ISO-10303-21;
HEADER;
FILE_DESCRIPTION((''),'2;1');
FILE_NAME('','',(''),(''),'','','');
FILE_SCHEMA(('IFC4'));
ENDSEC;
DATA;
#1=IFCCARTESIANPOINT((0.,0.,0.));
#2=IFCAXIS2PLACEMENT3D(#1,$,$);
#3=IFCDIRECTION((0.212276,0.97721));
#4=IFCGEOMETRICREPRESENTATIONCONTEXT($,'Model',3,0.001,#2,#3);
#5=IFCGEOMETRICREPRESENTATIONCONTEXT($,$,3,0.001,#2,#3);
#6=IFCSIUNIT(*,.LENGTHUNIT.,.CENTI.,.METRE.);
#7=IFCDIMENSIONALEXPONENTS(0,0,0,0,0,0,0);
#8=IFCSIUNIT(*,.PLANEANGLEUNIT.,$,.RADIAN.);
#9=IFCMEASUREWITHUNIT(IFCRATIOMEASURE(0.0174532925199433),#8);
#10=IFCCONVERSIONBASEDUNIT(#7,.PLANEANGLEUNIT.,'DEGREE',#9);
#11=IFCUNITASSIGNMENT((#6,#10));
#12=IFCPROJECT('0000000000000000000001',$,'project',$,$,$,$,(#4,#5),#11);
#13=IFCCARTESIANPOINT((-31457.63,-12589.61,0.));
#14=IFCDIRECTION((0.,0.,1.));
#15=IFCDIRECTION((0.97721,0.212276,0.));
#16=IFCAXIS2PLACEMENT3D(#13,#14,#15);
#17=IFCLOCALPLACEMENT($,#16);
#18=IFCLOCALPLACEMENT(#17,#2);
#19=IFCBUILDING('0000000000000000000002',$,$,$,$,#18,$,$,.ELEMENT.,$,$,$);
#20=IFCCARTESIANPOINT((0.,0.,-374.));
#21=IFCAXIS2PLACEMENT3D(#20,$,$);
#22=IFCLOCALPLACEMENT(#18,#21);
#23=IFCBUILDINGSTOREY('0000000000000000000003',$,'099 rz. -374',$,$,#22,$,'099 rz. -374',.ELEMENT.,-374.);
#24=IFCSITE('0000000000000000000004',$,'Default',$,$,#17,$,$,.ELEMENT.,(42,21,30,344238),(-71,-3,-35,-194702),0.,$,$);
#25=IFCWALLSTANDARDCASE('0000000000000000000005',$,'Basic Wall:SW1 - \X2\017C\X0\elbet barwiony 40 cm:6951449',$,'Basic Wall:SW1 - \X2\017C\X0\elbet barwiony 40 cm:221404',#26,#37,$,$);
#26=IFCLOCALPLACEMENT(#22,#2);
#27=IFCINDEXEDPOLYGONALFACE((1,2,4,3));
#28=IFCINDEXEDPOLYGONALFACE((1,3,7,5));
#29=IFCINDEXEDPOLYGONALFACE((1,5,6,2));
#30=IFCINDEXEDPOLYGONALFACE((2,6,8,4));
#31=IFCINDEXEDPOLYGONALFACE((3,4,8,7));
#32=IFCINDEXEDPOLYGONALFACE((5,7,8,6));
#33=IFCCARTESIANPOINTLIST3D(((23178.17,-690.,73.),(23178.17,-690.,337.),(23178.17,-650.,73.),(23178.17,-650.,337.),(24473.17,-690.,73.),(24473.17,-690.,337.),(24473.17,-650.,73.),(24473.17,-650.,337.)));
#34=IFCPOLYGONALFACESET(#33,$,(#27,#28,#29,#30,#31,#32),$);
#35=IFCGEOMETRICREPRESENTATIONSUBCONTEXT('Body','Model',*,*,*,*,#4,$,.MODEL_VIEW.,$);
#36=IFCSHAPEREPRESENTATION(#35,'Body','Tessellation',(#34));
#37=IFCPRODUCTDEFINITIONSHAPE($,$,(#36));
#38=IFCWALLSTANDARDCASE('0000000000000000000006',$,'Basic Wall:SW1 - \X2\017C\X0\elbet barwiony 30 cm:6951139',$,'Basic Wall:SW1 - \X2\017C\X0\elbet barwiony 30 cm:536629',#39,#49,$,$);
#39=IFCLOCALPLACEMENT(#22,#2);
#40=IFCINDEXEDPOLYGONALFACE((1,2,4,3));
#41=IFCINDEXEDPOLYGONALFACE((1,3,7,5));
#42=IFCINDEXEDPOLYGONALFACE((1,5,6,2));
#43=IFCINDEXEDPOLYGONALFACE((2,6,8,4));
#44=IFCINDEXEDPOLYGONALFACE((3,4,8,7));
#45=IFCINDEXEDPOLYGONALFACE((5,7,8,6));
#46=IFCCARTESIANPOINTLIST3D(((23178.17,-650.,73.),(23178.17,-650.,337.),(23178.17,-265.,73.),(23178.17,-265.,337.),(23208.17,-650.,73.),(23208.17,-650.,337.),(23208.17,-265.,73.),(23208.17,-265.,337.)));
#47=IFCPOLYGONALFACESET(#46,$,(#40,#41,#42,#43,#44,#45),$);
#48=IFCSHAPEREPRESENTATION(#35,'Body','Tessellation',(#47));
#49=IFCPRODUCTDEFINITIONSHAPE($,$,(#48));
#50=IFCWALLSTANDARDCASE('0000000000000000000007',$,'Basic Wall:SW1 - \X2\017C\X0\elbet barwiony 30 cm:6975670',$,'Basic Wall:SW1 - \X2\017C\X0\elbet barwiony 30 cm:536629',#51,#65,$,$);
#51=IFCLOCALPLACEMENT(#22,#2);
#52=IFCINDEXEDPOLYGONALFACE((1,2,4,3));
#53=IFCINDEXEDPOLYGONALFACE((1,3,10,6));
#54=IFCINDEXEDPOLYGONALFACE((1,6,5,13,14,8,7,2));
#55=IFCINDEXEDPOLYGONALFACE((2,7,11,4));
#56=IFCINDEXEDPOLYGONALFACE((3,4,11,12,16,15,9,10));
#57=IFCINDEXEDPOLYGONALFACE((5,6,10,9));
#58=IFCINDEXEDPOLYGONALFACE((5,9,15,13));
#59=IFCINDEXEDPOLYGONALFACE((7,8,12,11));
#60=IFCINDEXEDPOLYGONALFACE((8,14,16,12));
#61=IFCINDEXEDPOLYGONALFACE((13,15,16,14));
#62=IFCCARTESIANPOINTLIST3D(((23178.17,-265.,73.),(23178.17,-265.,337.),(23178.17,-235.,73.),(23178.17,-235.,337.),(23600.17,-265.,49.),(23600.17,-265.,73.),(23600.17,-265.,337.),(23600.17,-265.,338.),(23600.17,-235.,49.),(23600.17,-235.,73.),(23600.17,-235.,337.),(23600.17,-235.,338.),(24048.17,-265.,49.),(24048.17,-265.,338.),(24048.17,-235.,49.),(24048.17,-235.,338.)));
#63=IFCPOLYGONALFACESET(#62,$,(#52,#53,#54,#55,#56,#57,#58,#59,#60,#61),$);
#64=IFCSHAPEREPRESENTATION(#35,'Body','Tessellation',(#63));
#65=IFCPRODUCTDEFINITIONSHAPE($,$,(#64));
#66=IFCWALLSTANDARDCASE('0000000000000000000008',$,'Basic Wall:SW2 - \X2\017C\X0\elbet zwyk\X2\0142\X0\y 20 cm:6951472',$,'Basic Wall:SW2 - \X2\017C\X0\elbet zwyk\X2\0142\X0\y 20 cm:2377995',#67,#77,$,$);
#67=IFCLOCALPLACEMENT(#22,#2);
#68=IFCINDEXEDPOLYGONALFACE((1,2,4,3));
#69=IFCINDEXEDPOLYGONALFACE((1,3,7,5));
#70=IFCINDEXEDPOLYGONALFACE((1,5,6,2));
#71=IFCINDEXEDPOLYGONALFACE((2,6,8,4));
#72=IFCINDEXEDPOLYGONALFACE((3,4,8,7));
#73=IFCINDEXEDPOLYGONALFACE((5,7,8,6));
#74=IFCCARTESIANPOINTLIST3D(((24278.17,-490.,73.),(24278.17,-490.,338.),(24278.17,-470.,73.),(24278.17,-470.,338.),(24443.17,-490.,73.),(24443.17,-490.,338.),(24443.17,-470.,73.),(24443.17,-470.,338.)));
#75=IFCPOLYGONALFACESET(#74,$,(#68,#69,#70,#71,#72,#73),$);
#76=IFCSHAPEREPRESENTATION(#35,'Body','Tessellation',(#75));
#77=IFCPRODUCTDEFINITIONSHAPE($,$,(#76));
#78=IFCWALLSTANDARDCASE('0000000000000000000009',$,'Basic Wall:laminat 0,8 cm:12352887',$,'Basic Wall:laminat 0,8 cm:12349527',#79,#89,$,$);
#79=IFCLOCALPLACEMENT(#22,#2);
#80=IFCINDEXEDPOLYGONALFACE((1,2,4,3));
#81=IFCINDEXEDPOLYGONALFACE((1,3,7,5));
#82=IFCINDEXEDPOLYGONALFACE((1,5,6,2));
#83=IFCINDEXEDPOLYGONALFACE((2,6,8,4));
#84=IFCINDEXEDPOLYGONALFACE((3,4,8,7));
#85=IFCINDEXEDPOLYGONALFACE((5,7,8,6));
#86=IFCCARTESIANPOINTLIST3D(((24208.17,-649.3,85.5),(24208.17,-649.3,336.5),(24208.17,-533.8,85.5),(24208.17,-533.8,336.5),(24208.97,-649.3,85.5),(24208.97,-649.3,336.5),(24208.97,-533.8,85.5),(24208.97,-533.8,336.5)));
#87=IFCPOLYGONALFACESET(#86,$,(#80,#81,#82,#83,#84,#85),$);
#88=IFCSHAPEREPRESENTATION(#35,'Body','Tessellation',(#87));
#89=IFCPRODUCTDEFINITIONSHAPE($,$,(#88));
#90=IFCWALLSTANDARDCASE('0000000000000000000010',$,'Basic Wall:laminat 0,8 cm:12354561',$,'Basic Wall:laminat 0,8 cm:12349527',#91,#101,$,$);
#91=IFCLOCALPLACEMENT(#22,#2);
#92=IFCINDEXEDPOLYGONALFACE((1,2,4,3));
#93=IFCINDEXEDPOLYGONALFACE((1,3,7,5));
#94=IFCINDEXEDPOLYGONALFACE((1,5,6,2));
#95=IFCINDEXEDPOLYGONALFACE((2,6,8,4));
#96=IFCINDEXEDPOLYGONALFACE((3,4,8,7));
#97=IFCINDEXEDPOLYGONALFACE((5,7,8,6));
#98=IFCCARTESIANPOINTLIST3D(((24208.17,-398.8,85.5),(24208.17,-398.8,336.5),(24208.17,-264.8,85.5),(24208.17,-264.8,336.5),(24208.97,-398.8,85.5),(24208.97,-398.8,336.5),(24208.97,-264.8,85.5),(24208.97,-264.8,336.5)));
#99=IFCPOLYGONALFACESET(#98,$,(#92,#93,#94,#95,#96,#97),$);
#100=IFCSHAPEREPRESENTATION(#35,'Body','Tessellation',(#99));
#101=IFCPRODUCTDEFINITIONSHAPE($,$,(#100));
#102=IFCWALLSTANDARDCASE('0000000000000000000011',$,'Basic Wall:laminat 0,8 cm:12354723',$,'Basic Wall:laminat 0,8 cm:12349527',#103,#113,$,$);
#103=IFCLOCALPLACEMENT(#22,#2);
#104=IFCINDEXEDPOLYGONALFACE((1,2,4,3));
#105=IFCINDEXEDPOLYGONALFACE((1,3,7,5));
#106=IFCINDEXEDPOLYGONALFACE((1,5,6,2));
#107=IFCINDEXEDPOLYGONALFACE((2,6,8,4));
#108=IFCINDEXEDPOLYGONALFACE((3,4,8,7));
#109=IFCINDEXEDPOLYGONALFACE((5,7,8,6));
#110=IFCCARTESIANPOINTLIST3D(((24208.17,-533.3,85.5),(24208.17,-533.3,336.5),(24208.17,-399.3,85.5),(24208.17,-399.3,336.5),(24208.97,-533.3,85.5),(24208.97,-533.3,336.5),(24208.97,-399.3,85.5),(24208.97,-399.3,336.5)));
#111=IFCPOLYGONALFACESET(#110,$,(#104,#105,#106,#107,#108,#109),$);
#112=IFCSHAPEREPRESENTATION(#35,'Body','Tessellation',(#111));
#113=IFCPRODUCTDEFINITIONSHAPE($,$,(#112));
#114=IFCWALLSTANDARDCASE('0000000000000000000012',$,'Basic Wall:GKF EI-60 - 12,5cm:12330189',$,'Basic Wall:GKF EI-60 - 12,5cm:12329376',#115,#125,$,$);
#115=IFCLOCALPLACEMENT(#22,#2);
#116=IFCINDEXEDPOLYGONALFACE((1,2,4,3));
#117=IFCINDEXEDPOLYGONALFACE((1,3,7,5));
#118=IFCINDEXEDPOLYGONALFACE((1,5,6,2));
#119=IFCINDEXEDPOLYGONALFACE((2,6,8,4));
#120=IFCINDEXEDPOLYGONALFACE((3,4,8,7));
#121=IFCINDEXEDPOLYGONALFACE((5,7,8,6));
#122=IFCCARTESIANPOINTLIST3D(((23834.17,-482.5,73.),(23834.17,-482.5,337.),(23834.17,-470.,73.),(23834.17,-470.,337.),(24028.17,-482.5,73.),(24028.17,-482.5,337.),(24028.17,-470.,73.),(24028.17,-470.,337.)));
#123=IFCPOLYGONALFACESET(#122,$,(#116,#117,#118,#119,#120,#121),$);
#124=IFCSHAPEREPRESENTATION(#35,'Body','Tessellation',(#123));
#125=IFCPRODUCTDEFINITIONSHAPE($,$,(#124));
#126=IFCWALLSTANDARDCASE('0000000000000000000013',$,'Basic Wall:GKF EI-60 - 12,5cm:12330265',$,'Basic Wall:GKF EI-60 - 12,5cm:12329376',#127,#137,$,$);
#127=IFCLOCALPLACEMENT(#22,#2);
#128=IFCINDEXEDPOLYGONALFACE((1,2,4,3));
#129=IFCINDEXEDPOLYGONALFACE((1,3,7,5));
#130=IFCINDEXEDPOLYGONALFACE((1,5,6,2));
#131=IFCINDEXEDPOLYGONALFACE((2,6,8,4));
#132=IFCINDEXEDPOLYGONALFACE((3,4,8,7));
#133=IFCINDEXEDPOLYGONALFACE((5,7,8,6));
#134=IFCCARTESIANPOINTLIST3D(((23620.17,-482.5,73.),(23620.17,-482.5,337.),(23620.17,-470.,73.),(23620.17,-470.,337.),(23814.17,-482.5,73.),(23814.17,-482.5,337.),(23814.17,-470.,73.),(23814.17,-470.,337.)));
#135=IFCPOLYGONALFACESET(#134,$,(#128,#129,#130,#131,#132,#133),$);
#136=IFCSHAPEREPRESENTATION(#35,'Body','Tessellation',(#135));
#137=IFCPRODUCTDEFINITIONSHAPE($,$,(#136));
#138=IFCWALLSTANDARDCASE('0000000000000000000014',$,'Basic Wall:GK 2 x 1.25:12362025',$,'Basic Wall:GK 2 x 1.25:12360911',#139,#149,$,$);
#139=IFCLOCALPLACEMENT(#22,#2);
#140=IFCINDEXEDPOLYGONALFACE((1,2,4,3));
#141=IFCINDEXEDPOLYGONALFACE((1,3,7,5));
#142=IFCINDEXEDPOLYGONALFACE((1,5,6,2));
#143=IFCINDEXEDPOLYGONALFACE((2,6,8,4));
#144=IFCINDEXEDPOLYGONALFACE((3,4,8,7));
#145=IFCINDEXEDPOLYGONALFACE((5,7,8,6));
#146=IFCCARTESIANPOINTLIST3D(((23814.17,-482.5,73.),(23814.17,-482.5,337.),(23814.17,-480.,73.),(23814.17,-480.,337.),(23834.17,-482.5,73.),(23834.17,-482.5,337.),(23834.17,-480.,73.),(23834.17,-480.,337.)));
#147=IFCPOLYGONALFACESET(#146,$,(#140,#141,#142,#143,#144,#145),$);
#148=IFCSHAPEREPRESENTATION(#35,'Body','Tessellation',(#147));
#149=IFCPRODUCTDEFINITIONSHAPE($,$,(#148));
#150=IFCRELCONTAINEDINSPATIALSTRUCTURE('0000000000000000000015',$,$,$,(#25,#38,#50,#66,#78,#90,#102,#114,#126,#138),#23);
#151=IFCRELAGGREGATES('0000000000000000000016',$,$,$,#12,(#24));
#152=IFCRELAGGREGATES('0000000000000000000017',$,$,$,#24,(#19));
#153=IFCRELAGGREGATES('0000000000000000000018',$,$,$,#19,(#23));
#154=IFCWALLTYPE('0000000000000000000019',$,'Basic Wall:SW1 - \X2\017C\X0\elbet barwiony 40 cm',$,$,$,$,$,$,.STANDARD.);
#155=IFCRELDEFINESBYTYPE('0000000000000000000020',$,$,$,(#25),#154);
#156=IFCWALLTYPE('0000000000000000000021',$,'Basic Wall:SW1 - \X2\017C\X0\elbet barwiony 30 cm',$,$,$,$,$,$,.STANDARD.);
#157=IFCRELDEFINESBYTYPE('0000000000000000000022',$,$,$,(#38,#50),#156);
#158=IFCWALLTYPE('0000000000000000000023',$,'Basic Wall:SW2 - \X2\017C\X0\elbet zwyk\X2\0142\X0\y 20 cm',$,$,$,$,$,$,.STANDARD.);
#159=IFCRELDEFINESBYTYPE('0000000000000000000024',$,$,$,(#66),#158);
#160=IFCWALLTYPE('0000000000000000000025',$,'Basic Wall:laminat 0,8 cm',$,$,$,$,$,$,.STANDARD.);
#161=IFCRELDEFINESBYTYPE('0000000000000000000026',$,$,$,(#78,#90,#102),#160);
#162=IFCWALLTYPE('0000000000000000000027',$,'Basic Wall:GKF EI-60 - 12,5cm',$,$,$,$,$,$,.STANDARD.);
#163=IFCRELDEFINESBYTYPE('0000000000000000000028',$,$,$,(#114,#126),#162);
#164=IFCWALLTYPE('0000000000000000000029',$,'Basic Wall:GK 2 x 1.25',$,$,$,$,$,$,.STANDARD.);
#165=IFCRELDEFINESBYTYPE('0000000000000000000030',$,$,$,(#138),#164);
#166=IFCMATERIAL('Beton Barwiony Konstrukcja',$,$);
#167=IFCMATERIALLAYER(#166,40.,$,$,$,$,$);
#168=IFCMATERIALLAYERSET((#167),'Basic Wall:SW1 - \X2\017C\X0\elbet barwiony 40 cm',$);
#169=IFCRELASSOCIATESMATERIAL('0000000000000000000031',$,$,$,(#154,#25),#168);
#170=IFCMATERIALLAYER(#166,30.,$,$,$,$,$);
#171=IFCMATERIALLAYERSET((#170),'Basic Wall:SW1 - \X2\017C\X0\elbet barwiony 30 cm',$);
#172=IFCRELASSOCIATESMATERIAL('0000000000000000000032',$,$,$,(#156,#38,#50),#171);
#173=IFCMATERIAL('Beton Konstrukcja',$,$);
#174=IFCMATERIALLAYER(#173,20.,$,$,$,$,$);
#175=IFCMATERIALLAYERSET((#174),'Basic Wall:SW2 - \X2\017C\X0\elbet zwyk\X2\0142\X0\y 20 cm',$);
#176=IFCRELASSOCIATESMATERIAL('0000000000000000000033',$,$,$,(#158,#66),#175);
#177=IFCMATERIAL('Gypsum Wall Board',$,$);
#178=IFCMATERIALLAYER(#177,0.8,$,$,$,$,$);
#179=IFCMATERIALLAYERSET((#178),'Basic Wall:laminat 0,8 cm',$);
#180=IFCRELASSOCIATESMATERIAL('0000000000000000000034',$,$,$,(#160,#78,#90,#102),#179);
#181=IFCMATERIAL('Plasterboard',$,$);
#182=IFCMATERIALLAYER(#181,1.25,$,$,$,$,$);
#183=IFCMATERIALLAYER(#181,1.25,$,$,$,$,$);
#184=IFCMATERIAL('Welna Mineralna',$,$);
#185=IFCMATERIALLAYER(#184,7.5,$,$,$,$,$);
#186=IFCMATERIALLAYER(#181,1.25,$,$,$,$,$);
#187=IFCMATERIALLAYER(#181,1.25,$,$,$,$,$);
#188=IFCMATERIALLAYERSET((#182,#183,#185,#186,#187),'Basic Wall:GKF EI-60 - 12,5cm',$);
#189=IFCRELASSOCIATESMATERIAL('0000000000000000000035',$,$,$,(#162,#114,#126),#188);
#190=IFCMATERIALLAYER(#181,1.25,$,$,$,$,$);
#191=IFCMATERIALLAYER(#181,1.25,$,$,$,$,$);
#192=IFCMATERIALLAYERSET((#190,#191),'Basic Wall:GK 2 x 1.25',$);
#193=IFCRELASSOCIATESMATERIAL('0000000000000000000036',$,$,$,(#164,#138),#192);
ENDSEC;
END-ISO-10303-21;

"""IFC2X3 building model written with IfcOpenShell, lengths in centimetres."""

from ifc_helpers import new_model, entity, si_unit, converted_unit, direction, frame, frame_2d, origin, place, context, subcontext, project, spatial, polyline, rectangle, extrude, clip, bounded_halfspace, material, layer, layer_set, layer_usage, type_object, element, save


model = new_model("IFC2X3")

# Units and contexts
model_context = context("Model", 3, precision=0.001, world=origin(), true_north=direction((0.212276, 0.97721)))
context_of_model = context(None, 3, precision=0.001, world=origin(), true_north=direction((0.212276, 0.97721)))
body_context = subcontext(model_context, "Body", "Model", "MODEL_VIEW")
ifc_project = project(units=[si_unit("LENGTHUNIT", "METRE", prefix="CENTI"), converted_unit("PLANEANGLEUNIT", "DEGREE", entity("IfcRatioMeasure", 0.0174532925199433), si_unit("PLANEANGLEUNIT", "RADIAN"), dimensions=[0, 0, 0, 0, 0, 0, 0])], contexts=[model_context, context_of_model])

# Site, building, storey
site_placement = place(None, frame((-31457.63, -12589.61, 0.0), z_axis=(0.0, 0.0, 1.0), x_axis=(0.97721, 0.212276, 0.0)))
site = spatial("IfcSite", under=ifc_project, at=site_placement, Name="Default", CompositionType="ELEMENT", RefLatitude=(42, 21, 30, 344238), RefLongitude=(-71, -3, -35, -194702), RefElevation=0.0)
building_placement = place(site_placement, origin())
building = spatial("IfcBuilding", under=site, at=building_placement, CompositionType="ELEMENT")
storey_placement = place(building_placement, frame((0.0, 0.0, -374.0)))
storey = spatial("IfcBuildingStorey", under=building, at=storey_placement, Name="099 rz. -374", LongName="099 rz. -374", CompositionType="ELEMENT", Elevation=-374.0)

# Shared definitions
ifc_material_1 = material(Name="Beton Konstrukcja")

# Walls
ifc_material_2 = material(Name="Beton Barwiony Konstrukcja")
ifc_layer_1 = layer(ifc_material_2, 40.0)
ifc_layer_set_1 = layer_set([ifc_layer_1], Name="Basic Wall:SW1 - żelbet barwiony 40 cm")
ifc_layer_usage_1 = layer_usage(ifc_layer_set_1, "AXIS2", "POSITIVE", -20.0)
wall_type_1 = type_object("IfcWallType", Name="Basic Wall:SW1 - żelbet barwiony 40 cm", PredefinedType="STANDARD", material=ifc_layer_set_1)
wall_1_placement = place(storey_placement, frame((23178.17, -670.0, 73.0)))
element("IfcWallStandardCase", 1, at=wall_1_placement, inside=storey, type_object=wall_type_1, material=ifc_layer_usage_1, Name="Basic Wall:SW1 - żelbet barwiony 40 cm:6951449", ObjectType="Basic Wall:SW1 - żelbet barwiony 40 cm:221404", context=body_context, shape_type="Clipping", body=[
    clip(clip(extrude(rectangle(XDim=1295.0, YDim=40.0, at=frame_2d((647.5, 0.0), x_axis=(-1.0, 0.0))), origin(), (0.0, 0.0, 1.0), 265.0), bounded_halfspace(frame((1295.0, -20.0, 0.0), z_axis=(0.0, 0.0, 1.0), x_axis=(0.0, -1.0, 0.0)), True, frame((1295.0, -20.0, 0.0)), polyline([(0.0, 0.0), (0.0, 40.0), (-30.0, 40.0), (-1265.0, 40.0), (-1295.0, 40.0), (-1295.0, 0.0), (0.0, 0.0)]))), bounded_halfspace(frame((0.0, -20.0, 264.0), z_axis=(0.0, 0.0, -1.0), x_axis=(1.0, 0.0, 0.0)), True, frame((0.0, -20.0, 264.0), z_axis=(0.0, 0.0, -1.0), x_axis=(1.0, 0.0, 0.0)), polyline([(0.0, 0.0), (0.0, -40.0), (30.0, -40.0), (1265.0, -40.0), (1295.0, -40.0), (1295.0, 0.0), (0.0, 0.0)]))),
])
ifc_layer_2 = layer(ifc_material_2, 30.0)
ifc_layer_set_2 = layer_set([ifc_layer_2], Name="Basic Wall:SW1 - żelbet barwiony 30 cm")
ifc_layer_usage_2 = layer_usage(ifc_layer_set_2, "AXIS2", "POSITIVE", -15.0)
wall_type_2 = type_object("IfcWallType", Name="Basic Wall:SW1 - żelbet barwiony 30 cm", PredefinedType="STANDARD", material=ifc_layer_set_2)
wall_2_placement = place(storey_placement, frame((23193.17, -265.0, 73.0), z_axis=(0.0, 0.0, 1.0), x_axis=(0.0, -1.0, 0.0)))
element("IfcWallStandardCase", 2, at=wall_2_placement, inside=storey, type_object=wall_type_2, material=ifc_layer_usage_2, Name="Basic Wall:SW1 - żelbet barwiony 30 cm:6951139", ObjectType="Basic Wall:SW1 - żelbet barwiony 30 cm:536629", context=body_context, shape_type="Clipping", body=[
    clip(clip(extrude(rectangle(XDim=385.0, YDim=30.0, at=frame_2d((192.5, 0.0), x_axis=(-1.0, 0.0))), origin(), (0.0, 0.0, 1.0), 265.0), bounded_halfspace(frame((385.0, -15.0, 0.0)), True, frame((385.0, -15.0, 0.0)), polyline([(0.0, 0.0), (0.0, 30.0), (-385.0, 30.0), (-385.0, 0.0), (0.0, 0.0)]))), bounded_halfspace(frame((0.0, -15.0, 264.0), z_axis=(0.0, 0.0, -1.0), x_axis=(0.0, 1.0, 0.0)), True, frame((0.0, -15.0, 264.0), z_axis=(0.0, 0.0, -1.0), x_axis=(0.0, 1.0, 0.0)), polyline([(0.0, 0.0), (30.0, 0.0), (30.0, 385.0), (0.0, 385.0), (0.0, 0.0)]))),
])
ifc_layer_usage_3 = layer_usage(ifc_layer_set_2, "AXIS2", "POSITIVE", -15.0)
wall_3_placement = place(storey_placement, frame((24048.17, -250.0, 49.0), z_axis=(0.0, 0.0, 1.0), x_axis=(-1.0, 0.0, 0.0)))
element("IfcWallStandardCase", 3, at=wall_3_placement, inside=storey, type_object=wall_type_2, material=ifc_layer_usage_3, Name="Basic Wall:SW1 - żelbet barwiony 30 cm:6975670", ObjectType="Basic Wall:SW1 - żelbet barwiony 30 cm:536629", context=body_context, shape_type="Clipping", body=[
    clip(clip(clip(extrude(rectangle(XDim=870.0, YDim=30.0, at=frame_2d((435.0, 0.0), x_axis=(-1.0, 0.0))), origin(), (0.0, 0.0, 1.0), 289.0), bounded_halfspace(frame((870.0, 15.0, 24.0), z_axis=(0.0, 0.0, 1.0), x_axis=(0.0, 1.0, 0.0)), True, frame((870.0, 15.0, 24.0)), polyline([(0.0, 0.0), (-30.0, 0.0), (-422.0, 0.0), (-422.0, -30.0), (0.0, -30.0), (0.0, 0.0)]))), bounded_halfspace(frame((448.0, 15.0, 288.0), z_axis=(0.0, 0.0, -1.0), x_axis=(-1.0, 0.0, 0.0)), True, frame((448.0, 15.0, 288.0), z_axis=(0.0, 0.0, -1.0), x_axis=(-1.0, 0.0, 0.0)), polyline([(0.0, 0.0), (-392.0, 0.0), (-422.0, 0.0), (-422.0, -30.0), (0.0, -30.0), (0.0, 0.0)]))), bounded_halfspace(frame((448.0, -15.0, 288.0), z_axis=(-1.0, 0.0, 0.0), x_axis=(0.0, 0.0, 1.0)), True, frame((448.0, -15.0, 288.0), z_axis=(-1.0, 0.0, 0.0), x_axis=(0.0, 0.0, 1.0)), polyline([(0.0, 0.0), (1.0, 0.0), (1.0, 30.0), (0.0, 30.0), (0.0, 0.0)]))),
])

# Walls
ifc_layer_3 = layer(ifc_material_1, 20.0)
ifc_layer_set_3 = layer_set([ifc_layer_3], Name="Basic Wall:SW2 - żelbet zwykły 20 cm")
ifc_layer_usage_4 = layer_usage(ifc_layer_set_3, "AXIS2", "NEGATIVE", 10.0)
wall_type_3 = type_object("IfcWallType", Name="Basic Wall:SW2 - żelbet zwykły 20 cm", PredefinedType="STANDARD", material=ifc_layer_set_3)
wall_4_placement = place(storey_placement, frame((24278.17, -480.0, 73.0)))
element("IfcWallStandardCase", 4, at=wall_4_placement, inside=storey, type_object=wall_type_3, material=ifc_layer_usage_4, Name="Basic Wall:SW2 - żelbet zwykły 20 cm:6951472", ObjectType="Basic Wall:SW2 - żelbet zwykły 20 cm:2377995", context=body_context, shape_type="Clipping", body=[
    clip(extrude(rectangle(XDim=165.0, YDim=20.0, at=frame_2d((82.5, 0.0), x_axis=(-1.0, 0.0))), origin(), (0.0, 0.0, 1.0), 265.0), bounded_halfspace(frame((165.0, -10.0, 0.0), z_axis=(0.0, 0.0, 1.0), x_axis=(0.0, -1.0, 0.0)), True, frame((165.0, -10.0, 0.0)), polyline([(0.0, 0.0), (0.0, 20.0), (-165.0, 20.0), (-165.0, 0.0), (0.0, 0.0)]))),
])
ifc_material_3 = material(Name="Gypsum Wall Board")
ifc_layer_4 = layer(ifc_material_3, 0.8)
ifc_layer_set_4 = layer_set([ifc_layer_4], Name="Basic Wall:laminat 0,8 cm")
ifc_layer_usage_5 = layer_usage(ifc_layer_set_4, "AXIS2", "POSITIVE", -0.4)
wall_type_4 = type_object("IfcWallType", Name="Basic Wall:laminat 0,8 cm", PredefinedType="STANDARD", material=ifc_layer_set_4)
wall_5_placement = place(storey_placement, frame((24208.57, -649.3, 85.5), z_axis=(0.0, 0.0, 1.0), x_axis=(0.0, 1.0, 0.0)))
element("IfcWallStandardCase", 5, at=wall_5_placement, inside=storey, type_object=wall_type_4, material=ifc_layer_usage_5, Name="Basic Wall:laminat 0,8 cm:12352887", ObjectType="Basic Wall:laminat 0,8 cm:12349527", context=body_context, shape_type="SweptSolid", body=[
    extrude(rectangle(XDim=115.5, YDim=0.8, at=frame_2d((57.75, 0.0), x_axis=(-1.0, 0.0))), origin(), (0.0, 0.0, 1.0), 251.0),
])
ifc_layer_usage_6 = layer_usage(ifc_layer_set_4, "AXIS2", "POSITIVE", -0.4)
wall_6_placement = place(storey_placement, frame((24208.57, -398.8, 85.5), z_axis=(0.0, 0.0, 1.0), x_axis=(0.0, 1.0, 0.0)))
element("IfcWallStandardCase", 6, at=wall_6_placement, inside=storey, type_object=wall_type_4, material=ifc_layer_usage_6, Name="Basic Wall:laminat 0,8 cm:12354561", ObjectType="Basic Wall:laminat 0,8 cm:12349527", context=body_context, shape_type="SweptSolid", body=[
    extrude(rectangle(XDim=134.0, YDim=0.8, at=frame_2d((67.0, 0.0), x_axis=(-1.0, 0.0))), origin(), (0.0, 0.0, 1.0), 251.0),
])
ifc_layer_usage_7 = layer_usage(ifc_layer_set_4, "AXIS2", "POSITIVE", -0.4)
wall_7_placement = place(storey_placement, frame((24208.57, -533.3, 85.5), z_axis=(0.0, 0.0, 1.0), x_axis=(0.0, 1.0, 0.0)))
element("IfcWallStandardCase", 7, at=wall_7_placement, inside=storey, type_object=wall_type_4, material=ifc_layer_usage_7, Name="Basic Wall:laminat 0,8 cm:12354723", ObjectType="Basic Wall:laminat 0,8 cm:12349527", context=body_context, shape_type="SweptSolid", body=[
    extrude(rectangle(XDim=134.0, YDim=0.8, at=frame_2d((67.0, 0.0), x_axis=(-1.0, 0.0))), origin(), (0.0, 0.0, 1.0), 251.0),
])
ifc_material_4 = material(Name="Plasterboard")
ifc_layer_5 = layer(ifc_material_4, 1.25)
ifc_layer_6 = layer(ifc_material_4, 1.25)
ifc_material_5 = material(Name="Welna Mineralna")
ifc_layer_7 = layer(ifc_material_5, 7.5)
ifc_layer_8 = layer(ifc_material_4, 1.25)
ifc_layer_9 = layer(ifc_material_4, 1.25)
ifc_layer_set_5 = layer_set([ifc_layer_5, ifc_layer_6, ifc_layer_7, ifc_layer_8, ifc_layer_9], Name="Basic Wall:GKF EI-60 - 12,5cm")
ifc_layer_usage_8 = layer_usage(ifc_layer_set_5, "AXIS2", "NEGATIVE", 6.25)
wall_type_5 = type_object("IfcWallType", Name="Basic Wall:GKF EI-60 - 12,5cm", PredefinedType="STANDARD", material=ifc_layer_set_5)
wall_8_placement = place(storey_placement, frame((23834.17, -476.25, 73.0)))
element("IfcWallStandardCase", 8, at=wall_8_placement, inside=storey, type_object=wall_type_5, material=ifc_layer_usage_8, Name="Basic Wall:GKF EI-60 - 12,5cm:12330189", ObjectType="Basic Wall:GKF EI-60 - 12,5cm:12329376", context=body_context, shape_type="SweptSolid", body=[
    extrude(rectangle(XDim=194.0, YDim=12.5, at=frame_2d((97.0, 0.0), x_axis=(-1.0, 0.0))), origin(), (0.0, 0.0, 1.0), 264.0),
])
ifc_layer_usage_9 = layer_usage(ifc_layer_set_5, "AXIS2", "NEGATIVE", 6.25)
wall_9_placement = place(storey_placement, frame((23620.17, -476.25, 73.0)))
element("IfcWallStandardCase", 9, at=wall_9_placement, inside=storey, type_object=wall_type_5, material=ifc_layer_usage_9, Name="Basic Wall:GKF EI-60 - 12,5cm:12330265", ObjectType="Basic Wall:GKF EI-60 - 12,5cm:12329376", context=body_context, shape_type="SweptSolid", body=[
    extrude(rectangle(XDim=194.0, YDim=12.5, at=frame_2d((97.0, 0.0), x_axis=(-1.0, 0.0))), origin(), (0.0, 0.0, 1.0), 264.0),
])
ifc_layer_10 = layer(ifc_material_4, 1.25)
ifc_layer_11 = layer(ifc_material_4, 1.25)
ifc_layer_set_6 = layer_set([ifc_layer_10, ifc_layer_11], Name="Basic Wall:GK 2 x 1.25")
ifc_layer_usage_10 = layer_usage(ifc_layer_set_6, "AXIS2", "POSITIVE", -1.25)
wall_type_6 = type_object("IfcWallType", Name="Basic Wall:GK 2 x 1.25", PredefinedType="STANDARD", material=ifc_layer_set_6)
wall_10_placement = place(storey_placement, frame((23814.17, -481.25, 73.0)))
element("IfcWallStandardCase", 10, at=wall_10_placement, inside=storey, type_object=wall_type_6, material=ifc_layer_usage_10, Name="Basic Wall:GK 2 x 1.25:12362025", ObjectType="Basic Wall:GK 2 x 1.25:12360911", context=body_context, shape_type="SweptSolid", body=[
    extrude(rectangle(XDim=20.0, YDim=2.5, at=frame_2d((10.0, 0.0), x_axis=(-1.0, 0.0))), origin(), (0.0, 0.0, 1.0), 264.0),
])

save(model, "model.ifc")
